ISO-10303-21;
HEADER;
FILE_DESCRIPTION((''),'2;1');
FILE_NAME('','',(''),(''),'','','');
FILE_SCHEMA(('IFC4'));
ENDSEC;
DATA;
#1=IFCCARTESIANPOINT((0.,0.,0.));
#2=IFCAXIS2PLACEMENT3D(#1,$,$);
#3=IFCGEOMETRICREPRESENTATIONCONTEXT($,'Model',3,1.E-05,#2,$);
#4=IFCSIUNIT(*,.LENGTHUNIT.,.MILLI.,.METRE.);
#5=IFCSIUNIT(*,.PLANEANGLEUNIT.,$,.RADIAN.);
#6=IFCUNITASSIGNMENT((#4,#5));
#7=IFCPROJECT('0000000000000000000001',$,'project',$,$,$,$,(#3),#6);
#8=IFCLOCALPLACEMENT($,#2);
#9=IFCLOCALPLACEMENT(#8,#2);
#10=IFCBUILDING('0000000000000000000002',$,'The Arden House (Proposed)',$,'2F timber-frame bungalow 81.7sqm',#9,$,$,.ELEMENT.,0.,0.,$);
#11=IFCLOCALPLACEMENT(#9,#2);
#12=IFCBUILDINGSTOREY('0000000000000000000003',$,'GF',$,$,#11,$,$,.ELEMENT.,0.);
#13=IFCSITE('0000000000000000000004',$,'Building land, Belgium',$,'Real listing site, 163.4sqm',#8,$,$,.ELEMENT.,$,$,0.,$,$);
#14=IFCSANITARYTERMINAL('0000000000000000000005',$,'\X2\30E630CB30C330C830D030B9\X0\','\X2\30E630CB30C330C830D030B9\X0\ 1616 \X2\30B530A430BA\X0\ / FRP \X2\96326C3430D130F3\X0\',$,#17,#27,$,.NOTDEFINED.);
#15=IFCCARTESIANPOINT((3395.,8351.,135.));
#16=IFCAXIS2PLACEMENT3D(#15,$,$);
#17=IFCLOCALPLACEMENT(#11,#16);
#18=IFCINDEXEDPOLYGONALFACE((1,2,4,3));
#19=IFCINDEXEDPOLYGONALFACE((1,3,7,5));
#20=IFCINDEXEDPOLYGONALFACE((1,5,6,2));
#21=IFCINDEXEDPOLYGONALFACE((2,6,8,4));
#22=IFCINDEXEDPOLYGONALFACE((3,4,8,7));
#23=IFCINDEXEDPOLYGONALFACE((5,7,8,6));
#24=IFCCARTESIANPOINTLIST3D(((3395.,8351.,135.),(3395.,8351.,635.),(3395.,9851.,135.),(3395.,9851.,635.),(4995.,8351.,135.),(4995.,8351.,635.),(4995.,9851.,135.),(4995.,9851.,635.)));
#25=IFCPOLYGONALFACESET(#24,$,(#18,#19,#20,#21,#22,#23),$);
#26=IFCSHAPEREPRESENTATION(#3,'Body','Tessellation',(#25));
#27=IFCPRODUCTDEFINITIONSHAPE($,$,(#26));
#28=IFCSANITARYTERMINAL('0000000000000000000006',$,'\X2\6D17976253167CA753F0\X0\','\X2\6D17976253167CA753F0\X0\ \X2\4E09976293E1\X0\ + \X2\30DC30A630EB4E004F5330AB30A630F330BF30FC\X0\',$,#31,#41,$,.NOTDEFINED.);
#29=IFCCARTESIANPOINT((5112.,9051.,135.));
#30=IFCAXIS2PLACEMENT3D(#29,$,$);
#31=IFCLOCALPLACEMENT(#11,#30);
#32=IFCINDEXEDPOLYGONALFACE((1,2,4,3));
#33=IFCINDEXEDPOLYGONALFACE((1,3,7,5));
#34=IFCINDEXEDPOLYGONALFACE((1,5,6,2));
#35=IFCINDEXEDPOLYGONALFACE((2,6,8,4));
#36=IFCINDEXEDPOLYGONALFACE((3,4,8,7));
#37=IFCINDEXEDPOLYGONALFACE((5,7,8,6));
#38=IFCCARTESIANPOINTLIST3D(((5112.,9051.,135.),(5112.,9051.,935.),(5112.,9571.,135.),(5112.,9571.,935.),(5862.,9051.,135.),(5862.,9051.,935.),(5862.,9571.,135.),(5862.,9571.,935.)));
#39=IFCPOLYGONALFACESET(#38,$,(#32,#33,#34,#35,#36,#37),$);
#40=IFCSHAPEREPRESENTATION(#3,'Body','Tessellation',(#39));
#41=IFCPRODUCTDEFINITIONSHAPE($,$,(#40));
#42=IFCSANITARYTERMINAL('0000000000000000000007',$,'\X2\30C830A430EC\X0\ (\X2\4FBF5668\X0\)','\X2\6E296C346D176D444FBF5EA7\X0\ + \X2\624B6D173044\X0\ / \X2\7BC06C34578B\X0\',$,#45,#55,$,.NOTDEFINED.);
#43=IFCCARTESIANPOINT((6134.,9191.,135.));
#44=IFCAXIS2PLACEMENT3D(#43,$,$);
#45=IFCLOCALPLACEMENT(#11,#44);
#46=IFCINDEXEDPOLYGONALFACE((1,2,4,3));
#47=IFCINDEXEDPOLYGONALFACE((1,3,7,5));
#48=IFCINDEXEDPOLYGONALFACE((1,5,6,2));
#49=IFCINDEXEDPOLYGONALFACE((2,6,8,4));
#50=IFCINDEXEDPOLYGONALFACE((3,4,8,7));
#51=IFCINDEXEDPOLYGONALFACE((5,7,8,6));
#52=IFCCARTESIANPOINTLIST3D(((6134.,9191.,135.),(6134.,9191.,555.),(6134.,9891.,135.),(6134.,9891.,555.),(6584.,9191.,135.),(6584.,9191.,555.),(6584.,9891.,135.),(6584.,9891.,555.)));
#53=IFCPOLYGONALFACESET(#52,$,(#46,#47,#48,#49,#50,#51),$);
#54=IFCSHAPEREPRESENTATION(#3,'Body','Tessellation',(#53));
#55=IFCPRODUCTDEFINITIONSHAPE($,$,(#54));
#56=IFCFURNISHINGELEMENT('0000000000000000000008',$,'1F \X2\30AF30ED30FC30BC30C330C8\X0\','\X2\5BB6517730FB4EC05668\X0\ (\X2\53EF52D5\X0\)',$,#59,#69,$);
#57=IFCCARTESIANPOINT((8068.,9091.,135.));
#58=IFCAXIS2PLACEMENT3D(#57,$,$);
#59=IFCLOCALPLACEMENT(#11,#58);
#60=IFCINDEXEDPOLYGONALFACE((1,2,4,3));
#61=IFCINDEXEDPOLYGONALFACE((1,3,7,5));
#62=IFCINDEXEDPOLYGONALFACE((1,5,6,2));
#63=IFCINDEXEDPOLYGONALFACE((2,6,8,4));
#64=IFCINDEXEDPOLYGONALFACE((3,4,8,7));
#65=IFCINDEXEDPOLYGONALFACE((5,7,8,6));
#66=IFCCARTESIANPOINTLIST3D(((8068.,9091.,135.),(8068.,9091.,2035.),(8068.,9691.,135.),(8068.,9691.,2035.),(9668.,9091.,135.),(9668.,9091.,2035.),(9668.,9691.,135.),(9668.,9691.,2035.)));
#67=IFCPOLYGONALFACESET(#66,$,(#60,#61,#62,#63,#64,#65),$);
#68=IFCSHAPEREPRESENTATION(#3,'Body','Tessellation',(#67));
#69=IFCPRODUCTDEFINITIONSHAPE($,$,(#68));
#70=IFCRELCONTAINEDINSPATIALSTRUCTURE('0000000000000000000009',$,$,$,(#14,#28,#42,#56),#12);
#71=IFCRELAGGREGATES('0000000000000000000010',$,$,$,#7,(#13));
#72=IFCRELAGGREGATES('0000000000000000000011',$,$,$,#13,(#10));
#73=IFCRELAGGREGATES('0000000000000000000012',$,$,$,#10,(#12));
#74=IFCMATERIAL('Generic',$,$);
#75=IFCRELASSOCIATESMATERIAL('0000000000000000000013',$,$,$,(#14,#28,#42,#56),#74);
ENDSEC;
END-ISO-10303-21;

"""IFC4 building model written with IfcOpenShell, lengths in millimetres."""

from ifc_helpers import new_model, si_unit, frame, frame_2d, origin, place, context, project, spatial, rectangle, extrude, material, element, save


model = new_model("IFC4")

# Units and contexts
model_context = context("Model", 3, precision=1e-05, world=origin())
ifc_project = project(units=[si_unit("LENGTHUNIT", "METRE", prefix="MILLI"), si_unit("PLANEANGLEUNIT", "RADIAN")], contexts=[model_context])

# Site, building, storey
site_placement = place(None, origin())
site = spatial("IfcSite", under=ifc_project, at=site_placement, Name="Building land, Belgium", ObjectType="Real listing site, 163.4sqm", CompositionType="ELEMENT", RefElevation=0.0)
building_placement = place(site_placement, origin())
building = spatial("IfcBuilding", under=site, at=building_placement, Name="The Arden House (Proposed)", ObjectType="2F timber-frame bungalow 81.7sqm", CompositionType="ELEMENT", ElevationOfRefHeight=0.0, ElevationOfTerrain=0.0)
storey_placement = place(building_placement, origin())
storey = spatial("IfcBuildingStorey", under=building, at=storey_placement, Name="GF", CompositionType="ELEMENT", Elevation=0.0)

# Shared definitions
ifc_material_1 = material(Name="Generic")

# Sanitary terminals
sanitary_terminal_1_placement = place(storey_placement, frame((3395.0, 8351.0, 135.0)))
element("IfcSanitaryTerminal", 1, at=sanitary_terminal_1_placement, inside=storey, material=ifc_material_1, Name="ユニットバス", Description="ユニットバス 1616 サイズ / FRP 防水パン", PredefinedType="NOTDEFINED", context=model_context, shape_type="SweptSolid", body=[
    extrude(rectangle(XDim=1600.0, YDim=1500.0, at=frame_2d((800.0, 750.0))), frame((3395.0, 8351.0, 135.0)), (0.0, 0.0, 1.0), 500.0),
])
sanitary_terminal_2_placement = place(storey_placement, frame((5112.0, 9051.0, 135.0)))
element("IfcSanitaryTerminal", 2, at=sanitary_terminal_2_placement, inside=storey, material=ifc_material_1, Name="洗面化粧台", Description="洗面化粧台 三面鏡 + ボウル一体カウンター", PredefinedType="NOTDEFINED", context=model_context, shape_type="SweptSolid", body=[
    extrude(rectangle(XDim=750.0, YDim=520.0, at=frame_2d((375.0, 260.0))), frame((5112.0, 9051.0, 135.0)), (0.0, 0.0, 1.0), 800.0),
])
sanitary_terminal_3_placement = place(storey_placement, frame((6134.0, 9191.0, 135.0)))
element("IfcSanitaryTerminal", 3, at=sanitary_terminal_3_placement, inside=storey, material=ifc_material_1, Name="トイレ (便器)", Description="温水洗浄便座 + 手洗い / 節水型", PredefinedType="NOTDEFINED", context=model_context, shape_type="SweptSolid", body=[
    extrude(rectangle(XDim=450.0, YDim=700.0, at=frame_2d((225.0, 350.0))), frame((6134.0, 9191.0, 135.0)), (0.0, 0.0, 1.0), 420.0),
])

# Furnishing element
furnishing_placement = place(storey_placement, frame((8068.0, 9091.0, 135.0)))
element("IfcFurnishingElement", 4, at=furnishing_placement, inside=storey, material=ifc_material_1, Name="1F クローゼット", Description="家具・什器 (可動)", context=model_context, shape_type="SweptSolid", body=[
    extrude(rectangle(XDim=1600.0, YDim=600.0, at=frame_2d((800.0, 300.0))), frame((8068.0, 9091.0, 135.0)), (0.0, 0.0, 1.0), 1900.0),
])

save(model, "model.ifc")
